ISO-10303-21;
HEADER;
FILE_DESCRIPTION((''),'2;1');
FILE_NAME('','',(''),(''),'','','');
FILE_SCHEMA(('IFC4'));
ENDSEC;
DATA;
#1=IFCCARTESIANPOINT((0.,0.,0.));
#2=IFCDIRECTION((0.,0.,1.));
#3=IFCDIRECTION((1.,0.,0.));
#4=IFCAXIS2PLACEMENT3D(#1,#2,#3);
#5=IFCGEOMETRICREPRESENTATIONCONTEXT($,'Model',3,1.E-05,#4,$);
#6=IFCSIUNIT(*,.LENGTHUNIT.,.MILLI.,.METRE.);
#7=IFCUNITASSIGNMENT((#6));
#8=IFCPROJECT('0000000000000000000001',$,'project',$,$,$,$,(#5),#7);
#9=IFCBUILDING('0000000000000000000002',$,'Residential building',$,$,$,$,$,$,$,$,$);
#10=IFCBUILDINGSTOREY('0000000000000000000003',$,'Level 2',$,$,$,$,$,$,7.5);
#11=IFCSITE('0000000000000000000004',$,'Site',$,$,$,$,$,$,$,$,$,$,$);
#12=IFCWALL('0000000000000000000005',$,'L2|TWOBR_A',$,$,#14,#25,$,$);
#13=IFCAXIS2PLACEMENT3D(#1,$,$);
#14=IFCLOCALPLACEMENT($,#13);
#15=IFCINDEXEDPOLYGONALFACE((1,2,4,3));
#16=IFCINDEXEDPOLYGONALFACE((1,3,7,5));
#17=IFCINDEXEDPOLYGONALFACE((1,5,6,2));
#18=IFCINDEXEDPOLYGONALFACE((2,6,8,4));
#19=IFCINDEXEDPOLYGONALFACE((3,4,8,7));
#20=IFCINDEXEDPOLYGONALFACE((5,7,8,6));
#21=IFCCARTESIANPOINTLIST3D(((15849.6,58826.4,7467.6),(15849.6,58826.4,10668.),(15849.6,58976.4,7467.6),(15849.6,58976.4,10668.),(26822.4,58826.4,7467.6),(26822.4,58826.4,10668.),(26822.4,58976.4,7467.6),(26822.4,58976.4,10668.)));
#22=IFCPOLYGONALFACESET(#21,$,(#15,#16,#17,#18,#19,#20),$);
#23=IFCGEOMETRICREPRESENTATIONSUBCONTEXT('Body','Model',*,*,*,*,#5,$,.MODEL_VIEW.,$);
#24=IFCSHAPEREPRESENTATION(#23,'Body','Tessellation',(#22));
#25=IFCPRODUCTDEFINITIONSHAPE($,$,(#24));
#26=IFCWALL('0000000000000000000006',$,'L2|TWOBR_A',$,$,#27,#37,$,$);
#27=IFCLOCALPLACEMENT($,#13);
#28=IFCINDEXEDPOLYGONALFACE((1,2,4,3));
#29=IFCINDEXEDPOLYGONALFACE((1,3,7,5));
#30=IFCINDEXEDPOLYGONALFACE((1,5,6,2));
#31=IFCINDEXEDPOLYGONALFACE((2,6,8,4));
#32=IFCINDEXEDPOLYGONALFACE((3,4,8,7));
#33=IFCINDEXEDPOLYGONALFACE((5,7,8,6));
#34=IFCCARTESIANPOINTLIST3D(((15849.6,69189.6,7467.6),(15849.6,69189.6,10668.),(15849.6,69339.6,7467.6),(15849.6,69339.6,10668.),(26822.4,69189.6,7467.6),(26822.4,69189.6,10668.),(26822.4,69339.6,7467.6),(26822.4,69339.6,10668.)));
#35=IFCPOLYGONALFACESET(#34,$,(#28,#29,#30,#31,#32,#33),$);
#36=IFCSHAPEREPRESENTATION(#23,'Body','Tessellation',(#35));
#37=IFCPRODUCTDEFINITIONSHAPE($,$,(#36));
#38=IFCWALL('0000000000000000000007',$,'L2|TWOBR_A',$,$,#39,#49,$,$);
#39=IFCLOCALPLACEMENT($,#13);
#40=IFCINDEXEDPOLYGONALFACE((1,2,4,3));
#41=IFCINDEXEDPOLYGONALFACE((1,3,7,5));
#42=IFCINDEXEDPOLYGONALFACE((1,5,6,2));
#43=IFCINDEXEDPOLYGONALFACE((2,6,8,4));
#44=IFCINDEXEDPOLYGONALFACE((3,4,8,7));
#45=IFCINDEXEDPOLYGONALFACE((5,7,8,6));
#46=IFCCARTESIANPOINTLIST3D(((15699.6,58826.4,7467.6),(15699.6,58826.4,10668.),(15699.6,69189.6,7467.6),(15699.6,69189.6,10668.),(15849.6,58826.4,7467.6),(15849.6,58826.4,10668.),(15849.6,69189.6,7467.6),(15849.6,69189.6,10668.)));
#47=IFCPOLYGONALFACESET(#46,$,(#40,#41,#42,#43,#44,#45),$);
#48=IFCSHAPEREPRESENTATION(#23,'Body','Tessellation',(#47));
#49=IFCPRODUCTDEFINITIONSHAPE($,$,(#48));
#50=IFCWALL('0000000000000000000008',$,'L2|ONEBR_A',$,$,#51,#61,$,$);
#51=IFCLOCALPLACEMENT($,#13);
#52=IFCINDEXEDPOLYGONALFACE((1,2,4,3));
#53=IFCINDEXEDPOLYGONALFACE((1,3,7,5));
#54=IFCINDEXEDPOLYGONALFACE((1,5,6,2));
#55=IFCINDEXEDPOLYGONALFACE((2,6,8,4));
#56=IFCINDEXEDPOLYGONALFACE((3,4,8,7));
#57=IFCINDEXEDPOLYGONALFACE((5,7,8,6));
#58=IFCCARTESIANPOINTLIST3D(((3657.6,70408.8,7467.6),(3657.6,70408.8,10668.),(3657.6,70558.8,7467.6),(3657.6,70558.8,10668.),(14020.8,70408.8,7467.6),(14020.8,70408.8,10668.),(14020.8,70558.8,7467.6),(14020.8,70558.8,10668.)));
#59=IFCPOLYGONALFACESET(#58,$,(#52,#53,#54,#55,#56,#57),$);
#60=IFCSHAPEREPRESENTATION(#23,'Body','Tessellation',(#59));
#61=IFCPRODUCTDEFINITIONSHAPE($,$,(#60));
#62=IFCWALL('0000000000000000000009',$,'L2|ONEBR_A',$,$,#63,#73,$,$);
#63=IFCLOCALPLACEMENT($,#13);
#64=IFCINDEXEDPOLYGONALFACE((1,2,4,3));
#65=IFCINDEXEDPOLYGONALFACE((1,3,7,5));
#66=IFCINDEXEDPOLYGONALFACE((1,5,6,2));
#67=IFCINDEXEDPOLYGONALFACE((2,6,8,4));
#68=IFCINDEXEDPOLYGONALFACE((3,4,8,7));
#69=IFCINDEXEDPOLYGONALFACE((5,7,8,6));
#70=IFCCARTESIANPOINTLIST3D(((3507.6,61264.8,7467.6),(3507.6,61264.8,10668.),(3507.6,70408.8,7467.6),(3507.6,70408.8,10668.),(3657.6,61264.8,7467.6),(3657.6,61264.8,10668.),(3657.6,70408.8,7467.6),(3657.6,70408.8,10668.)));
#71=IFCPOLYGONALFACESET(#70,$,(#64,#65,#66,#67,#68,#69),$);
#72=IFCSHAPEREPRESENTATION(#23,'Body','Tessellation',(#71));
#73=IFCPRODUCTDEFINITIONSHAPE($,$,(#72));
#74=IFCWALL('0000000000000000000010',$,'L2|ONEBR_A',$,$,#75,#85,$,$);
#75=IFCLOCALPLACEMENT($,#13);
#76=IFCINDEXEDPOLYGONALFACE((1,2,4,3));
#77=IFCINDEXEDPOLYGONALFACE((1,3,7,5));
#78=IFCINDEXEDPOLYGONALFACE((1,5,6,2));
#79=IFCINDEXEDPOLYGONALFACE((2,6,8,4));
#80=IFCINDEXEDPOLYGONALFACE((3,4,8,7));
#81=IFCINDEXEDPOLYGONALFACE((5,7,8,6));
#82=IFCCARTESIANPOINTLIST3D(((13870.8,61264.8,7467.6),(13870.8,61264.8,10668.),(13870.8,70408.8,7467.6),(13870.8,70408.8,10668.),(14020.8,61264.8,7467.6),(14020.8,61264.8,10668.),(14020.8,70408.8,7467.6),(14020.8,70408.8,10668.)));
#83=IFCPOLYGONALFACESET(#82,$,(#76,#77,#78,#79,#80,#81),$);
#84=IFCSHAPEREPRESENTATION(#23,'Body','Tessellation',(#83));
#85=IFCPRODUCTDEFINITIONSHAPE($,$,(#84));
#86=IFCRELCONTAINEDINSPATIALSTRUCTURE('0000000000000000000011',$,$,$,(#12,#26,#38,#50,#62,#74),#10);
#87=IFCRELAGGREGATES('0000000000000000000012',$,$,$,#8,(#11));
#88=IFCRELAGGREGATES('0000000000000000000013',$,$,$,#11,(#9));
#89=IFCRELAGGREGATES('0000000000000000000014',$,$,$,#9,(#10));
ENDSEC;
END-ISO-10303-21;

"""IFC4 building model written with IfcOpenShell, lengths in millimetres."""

from ifc_helpers import new_model, si_unit, frame, origin_with_axes, place, context, subcontext, project, spatial, indexed_curve, outline, extrude, element, save


model = new_model("IFC4")

# Units and contexts
model_context = context("Model", 3, precision=1e-05, world=origin_with_axes())
body_context = subcontext(model_context, "Body", "Model", "MODEL_VIEW")
ifc_project = project(units=[si_unit("LENGTHUNIT", "METRE", prefix="MILLI")], contexts=[model_context])

# Site, building, storey
site = spatial("IfcSite", under=ifc_project, Name="Site")
building = spatial("IfcBuilding", under=site, Name="Residential building")
storey = spatial("IfcBuildingStorey", under=building, Name="Level 2", Elevation=7.5)

# Walls
for number, where, z_axis, x_axis, name in (
    (1, (15849.6, 58826.4, 7467.6), (0.0, 0.0, 1.0), (1.0, 0.0, 0.0), "L2|TWOBR_A"),
    (2, (15849.6, 69189.6, 7467.6), (0.0, 0.0, 1.0), (1.0, 0.0, 0.0), "L2|TWOBR_A"),
):
    element("IfcWall", number, at=place(None, frame(where, z_axis=z_axis, x_axis=x_axis)), inside=storey, Name=name, context=body_context, shape_type="SweptSolid", body=[
        extrude(outline(indexed_curve([(0.0, 0.0), (0.0, 150.0), (10972.8, 150.0), (10972.8, 0.0), (0.0, 0.0)], self_intersect=False)), origin_with_axes(), (0.0, 0.0, 1.0), 3200.4),
    ])
for number, where, z_axis, x_axis, name in (
    (3, (15849.6, 58826.4, 7467.6), (0.0, 0.0, 1.0), (0.0, 1.0, 0.0), "L2|TWOBR_A"),
    (4, (3657.6, 70408.8, 7467.6), (0.0, 0.0, 1.0), (1.0, 0.0, 0.0), "L2|ONEBR_A"),
):
    element("IfcWall", number, at=place(None, frame(where, z_axis=z_axis, x_axis=x_axis)), inside=storey, Name=name, context=body_context, shape_type="SweptSolid", body=[
        extrude(outline(indexed_curve([(0.0, 0.0), (0.0, 150.0), (10363.2, 150.0), (10363.2, 0.0), (0.0, 0.0)], self_intersect=False)), origin_with_axes(), (0.0, 0.0, 1.0), 3200.4),
    ])
for number, where, z_axis, x_axis, name in (
    (5, (3657.6, 61264.8, 7467.6), (0.0, 0.0, 1.0), (0.0, 1.0, 0.0), "L2|ONEBR_A"),
    (6, (14020.8, 61264.8, 7467.6), (0.0, 0.0, 1.0), (0.0, 1.0, 0.0), "L2|ONEBR_A"),
):
    element("IfcWall", number, at=place(None, frame(where, z_axis=z_axis, x_axis=x_axis)), inside=storey, Name=name, context=body_context, shape_type="SweptSolid", body=[
        extrude(outline(indexed_curve([(0.0, 0.0), (0.0, 150.0), (9144.0, 150.0), (9144.0, 0.0), (0.0, 0.0)], self_intersect=False)), origin_with_axes(), (0.0, 0.0, 1.0), 3200.4),
    ])

save(model, "model.ifc")
